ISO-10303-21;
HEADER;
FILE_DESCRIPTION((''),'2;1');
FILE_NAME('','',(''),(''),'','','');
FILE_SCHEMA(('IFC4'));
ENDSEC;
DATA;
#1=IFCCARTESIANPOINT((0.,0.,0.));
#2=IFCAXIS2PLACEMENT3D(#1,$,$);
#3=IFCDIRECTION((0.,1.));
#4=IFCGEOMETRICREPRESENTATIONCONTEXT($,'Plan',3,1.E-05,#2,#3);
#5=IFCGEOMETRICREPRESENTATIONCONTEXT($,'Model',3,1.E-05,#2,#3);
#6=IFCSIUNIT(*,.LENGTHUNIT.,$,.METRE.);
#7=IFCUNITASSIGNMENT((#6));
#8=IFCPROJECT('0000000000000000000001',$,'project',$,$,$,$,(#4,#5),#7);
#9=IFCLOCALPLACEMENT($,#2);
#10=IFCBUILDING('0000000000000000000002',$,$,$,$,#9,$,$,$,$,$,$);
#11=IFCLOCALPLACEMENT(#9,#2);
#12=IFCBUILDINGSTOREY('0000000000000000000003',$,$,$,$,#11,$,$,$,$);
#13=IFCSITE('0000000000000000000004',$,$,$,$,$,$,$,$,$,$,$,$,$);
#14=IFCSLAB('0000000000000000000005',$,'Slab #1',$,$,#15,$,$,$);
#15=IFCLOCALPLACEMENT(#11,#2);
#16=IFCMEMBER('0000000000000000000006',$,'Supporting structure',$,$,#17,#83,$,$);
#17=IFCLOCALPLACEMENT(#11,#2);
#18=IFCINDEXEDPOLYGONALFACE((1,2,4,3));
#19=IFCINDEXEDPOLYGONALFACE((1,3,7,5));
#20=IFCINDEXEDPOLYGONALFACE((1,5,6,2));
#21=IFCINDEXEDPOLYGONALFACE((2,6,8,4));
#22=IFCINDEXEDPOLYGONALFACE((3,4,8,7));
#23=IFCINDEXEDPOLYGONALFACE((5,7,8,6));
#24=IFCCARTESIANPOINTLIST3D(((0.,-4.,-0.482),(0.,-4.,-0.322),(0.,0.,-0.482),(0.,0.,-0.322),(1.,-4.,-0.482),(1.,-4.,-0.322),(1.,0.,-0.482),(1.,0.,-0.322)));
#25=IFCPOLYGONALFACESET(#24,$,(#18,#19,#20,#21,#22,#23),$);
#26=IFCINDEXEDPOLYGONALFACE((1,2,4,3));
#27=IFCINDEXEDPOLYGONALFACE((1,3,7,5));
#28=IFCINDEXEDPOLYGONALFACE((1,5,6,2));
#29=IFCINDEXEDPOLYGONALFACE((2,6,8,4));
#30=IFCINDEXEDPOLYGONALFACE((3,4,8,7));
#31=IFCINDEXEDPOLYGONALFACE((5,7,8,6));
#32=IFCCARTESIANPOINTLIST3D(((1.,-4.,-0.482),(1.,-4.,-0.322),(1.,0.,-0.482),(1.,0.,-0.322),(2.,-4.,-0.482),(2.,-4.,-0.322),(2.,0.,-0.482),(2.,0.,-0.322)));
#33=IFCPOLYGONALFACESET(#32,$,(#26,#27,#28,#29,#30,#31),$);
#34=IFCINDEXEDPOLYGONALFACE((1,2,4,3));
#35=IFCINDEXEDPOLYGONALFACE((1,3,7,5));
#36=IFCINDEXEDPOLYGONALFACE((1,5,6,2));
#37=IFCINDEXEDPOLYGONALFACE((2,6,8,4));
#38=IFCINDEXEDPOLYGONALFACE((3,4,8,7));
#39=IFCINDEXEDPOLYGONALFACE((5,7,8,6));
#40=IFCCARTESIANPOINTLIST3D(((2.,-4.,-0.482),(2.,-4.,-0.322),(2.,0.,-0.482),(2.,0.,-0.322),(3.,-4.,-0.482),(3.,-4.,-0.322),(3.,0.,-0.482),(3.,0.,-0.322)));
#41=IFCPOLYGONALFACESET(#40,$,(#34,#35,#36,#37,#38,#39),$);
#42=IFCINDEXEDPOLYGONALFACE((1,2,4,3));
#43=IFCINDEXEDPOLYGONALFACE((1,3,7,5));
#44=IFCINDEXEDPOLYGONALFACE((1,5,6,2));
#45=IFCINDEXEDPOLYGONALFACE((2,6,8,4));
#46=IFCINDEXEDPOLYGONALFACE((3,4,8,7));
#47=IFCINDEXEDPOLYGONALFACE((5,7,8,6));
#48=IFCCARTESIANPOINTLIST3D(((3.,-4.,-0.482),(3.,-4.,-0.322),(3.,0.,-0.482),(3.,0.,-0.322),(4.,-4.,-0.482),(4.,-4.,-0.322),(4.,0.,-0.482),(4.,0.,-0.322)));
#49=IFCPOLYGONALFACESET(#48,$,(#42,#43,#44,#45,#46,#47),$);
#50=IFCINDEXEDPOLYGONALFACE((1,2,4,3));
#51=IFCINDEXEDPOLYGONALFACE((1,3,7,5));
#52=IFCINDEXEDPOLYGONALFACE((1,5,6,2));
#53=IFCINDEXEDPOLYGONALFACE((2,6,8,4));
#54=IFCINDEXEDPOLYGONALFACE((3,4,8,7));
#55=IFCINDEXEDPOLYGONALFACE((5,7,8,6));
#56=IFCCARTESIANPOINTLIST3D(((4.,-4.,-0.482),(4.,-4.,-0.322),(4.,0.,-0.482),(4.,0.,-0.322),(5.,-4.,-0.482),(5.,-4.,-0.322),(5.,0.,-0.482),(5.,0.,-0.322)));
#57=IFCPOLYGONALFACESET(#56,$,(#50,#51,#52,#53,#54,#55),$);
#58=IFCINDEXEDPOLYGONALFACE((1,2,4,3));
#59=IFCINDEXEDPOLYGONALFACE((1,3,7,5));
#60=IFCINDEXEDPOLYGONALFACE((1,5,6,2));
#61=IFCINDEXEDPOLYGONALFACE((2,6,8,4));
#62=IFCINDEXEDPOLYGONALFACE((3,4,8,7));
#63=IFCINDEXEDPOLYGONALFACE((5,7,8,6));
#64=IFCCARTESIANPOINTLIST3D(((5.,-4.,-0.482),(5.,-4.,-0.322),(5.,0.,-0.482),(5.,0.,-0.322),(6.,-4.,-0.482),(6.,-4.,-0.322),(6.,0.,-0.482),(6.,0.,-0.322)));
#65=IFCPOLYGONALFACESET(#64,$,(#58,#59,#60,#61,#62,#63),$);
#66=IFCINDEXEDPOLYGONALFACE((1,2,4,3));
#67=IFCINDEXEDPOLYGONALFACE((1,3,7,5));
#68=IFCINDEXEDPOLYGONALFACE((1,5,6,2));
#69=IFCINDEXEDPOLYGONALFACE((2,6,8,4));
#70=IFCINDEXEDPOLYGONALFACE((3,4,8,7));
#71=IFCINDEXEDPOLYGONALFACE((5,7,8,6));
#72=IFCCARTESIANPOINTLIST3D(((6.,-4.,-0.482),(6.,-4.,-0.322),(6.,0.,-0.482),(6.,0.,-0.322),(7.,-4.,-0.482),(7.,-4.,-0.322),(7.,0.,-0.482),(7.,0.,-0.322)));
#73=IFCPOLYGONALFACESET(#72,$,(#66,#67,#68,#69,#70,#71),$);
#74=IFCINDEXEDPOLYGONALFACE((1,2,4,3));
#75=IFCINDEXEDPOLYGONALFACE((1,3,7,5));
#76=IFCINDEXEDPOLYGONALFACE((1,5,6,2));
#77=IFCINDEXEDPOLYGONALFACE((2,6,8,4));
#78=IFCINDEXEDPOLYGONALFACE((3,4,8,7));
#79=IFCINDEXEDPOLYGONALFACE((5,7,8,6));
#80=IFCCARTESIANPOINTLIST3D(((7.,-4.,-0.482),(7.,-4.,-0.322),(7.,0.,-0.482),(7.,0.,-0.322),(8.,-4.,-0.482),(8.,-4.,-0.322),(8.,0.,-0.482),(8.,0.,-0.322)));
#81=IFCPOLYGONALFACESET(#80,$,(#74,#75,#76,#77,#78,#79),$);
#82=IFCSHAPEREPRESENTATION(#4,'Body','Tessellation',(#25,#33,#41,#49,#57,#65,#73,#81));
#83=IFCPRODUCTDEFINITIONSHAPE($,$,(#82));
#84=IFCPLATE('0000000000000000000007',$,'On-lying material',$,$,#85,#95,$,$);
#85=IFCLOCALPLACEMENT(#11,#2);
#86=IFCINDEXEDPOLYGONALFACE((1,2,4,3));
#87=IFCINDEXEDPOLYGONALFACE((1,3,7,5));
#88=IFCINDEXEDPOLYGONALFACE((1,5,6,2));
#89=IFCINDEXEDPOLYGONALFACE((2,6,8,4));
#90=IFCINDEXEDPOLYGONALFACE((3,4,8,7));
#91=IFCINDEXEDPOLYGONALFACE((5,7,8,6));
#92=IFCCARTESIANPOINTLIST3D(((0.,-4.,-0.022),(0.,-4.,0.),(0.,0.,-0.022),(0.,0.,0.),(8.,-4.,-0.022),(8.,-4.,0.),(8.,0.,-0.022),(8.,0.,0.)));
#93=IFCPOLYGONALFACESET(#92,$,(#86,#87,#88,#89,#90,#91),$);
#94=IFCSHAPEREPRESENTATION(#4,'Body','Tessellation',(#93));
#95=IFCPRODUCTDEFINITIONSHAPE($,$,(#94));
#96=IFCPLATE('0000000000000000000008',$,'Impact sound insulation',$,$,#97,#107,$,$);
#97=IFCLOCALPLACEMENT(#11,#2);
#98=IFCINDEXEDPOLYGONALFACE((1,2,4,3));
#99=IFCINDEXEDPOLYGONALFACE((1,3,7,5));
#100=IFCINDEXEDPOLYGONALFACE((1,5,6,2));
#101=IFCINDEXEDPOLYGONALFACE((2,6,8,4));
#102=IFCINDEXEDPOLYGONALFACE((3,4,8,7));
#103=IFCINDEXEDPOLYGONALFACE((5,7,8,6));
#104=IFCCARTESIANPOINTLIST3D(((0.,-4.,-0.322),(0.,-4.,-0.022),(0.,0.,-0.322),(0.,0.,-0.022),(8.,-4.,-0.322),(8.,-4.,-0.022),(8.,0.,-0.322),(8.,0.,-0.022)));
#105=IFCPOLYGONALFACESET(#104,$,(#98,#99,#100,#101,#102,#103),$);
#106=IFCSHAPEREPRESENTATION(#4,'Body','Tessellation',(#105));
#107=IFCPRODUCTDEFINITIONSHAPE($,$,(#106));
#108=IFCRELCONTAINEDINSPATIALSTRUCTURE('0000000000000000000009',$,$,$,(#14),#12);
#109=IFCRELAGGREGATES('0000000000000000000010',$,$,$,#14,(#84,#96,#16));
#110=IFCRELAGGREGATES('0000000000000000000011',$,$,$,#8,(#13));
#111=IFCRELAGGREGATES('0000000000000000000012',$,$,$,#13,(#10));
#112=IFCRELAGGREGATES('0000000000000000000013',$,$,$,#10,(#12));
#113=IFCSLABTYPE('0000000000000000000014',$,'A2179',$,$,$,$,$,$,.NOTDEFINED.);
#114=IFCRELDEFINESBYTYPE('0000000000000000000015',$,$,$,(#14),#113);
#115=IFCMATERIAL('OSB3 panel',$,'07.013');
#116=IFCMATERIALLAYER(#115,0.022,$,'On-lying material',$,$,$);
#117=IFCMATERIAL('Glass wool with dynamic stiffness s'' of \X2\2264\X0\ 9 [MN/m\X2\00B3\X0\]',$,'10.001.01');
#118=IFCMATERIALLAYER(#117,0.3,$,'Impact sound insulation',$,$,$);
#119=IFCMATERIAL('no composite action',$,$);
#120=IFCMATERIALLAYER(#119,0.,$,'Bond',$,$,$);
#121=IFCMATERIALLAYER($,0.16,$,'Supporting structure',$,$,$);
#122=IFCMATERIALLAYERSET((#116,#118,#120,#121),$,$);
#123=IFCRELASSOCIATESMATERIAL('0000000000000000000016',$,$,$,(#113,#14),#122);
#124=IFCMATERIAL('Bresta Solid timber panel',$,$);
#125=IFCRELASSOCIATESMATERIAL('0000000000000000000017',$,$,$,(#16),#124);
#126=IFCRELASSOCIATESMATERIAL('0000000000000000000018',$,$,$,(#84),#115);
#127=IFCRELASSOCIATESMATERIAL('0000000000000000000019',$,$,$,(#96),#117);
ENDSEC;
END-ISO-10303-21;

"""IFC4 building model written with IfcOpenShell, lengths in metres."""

from ifc_helpers import new_model, si_unit, direction, frame, frame_2d, origin, origin_with_axes, place, context, project, spatial, rectangle, extrude, material, layer, layer_set, type_object, element, aggregate, save


model = new_model("IFC4")

# Units and contexts
plan_context = context("Plan", 3, precision=1e-05, world=origin(), true_north=direction((0.0, 1.0)))
model_context = context("Model", 3, precision=1e-05, world=origin(), true_north=direction((0.0, 1.0)))
ifc_project = project(units=[si_unit("LENGTHUNIT", "METRE")], contexts=[plan_context, model_context])

# Site, building, storey
site = spatial("IfcSite", under=ifc_project)
building_placement = place(None, origin())
building = spatial("IfcBuilding", under=site, at=building_placement)
storey_placement = place(building_placement, origin())
storey = spatial("IfcBuildingStorey", under=building, at=storey_placement)

# Slab, member, plates
ifc_material_1 = material(Name="OSB3 panel", Category="07.013")
ifc_layer_1 = layer(ifc_material_1, 0.022, Name="On-lying material")
ifc_material_2 = material(Name="Glass wool with dynamic stiffness s' of ≤ 9 [MN/m³]", Category="10.001.01")
ifc_layer_2 = layer(ifc_material_2, 0.3, Name="Impact sound insulation")
ifc_material_3 = material(Name="no composite action")
ifc_layer_3 = layer(ifc_material_3, 0.0, Name="Bond")
ifc_layer_4 = layer(None, 0.16, Name="Supporting structure")
ifc_layer_set = layer_set([ifc_layer_1, ifc_layer_2, ifc_layer_3, ifc_layer_4])
slab_type = type_object("IfcSlabType", Name="A2179", PredefinedType="NOTDEFINED", material=ifc_layer_set)
slab_placement = place(None, frame((0.0, 0.0, 0.0), z_axis=(0.0, 0.0, -1.0), x_axis=(1.0, 0.0, 0.0)))
slab = element("IfcSlab", 1, at=slab_placement, inside=storey, type_object=slab_type, material=ifc_layer_set, Name="Slab #1")
ifc_material_4 = material(Name="Bresta Solid timber panel")
member_placement = place(slab_placement, origin())
member = element("IfcMember", 2, at=member_placement, material=ifc_material_4, Name="Supporting structure", context=plan_context, shape_type="SweptSolid", body=[
    extrude(rectangle(XDim=1.0, YDim=0.16, at=frame_2d((0.5, 0.08), x_axis=(1.0, 0.0))), frame((0.0, 4.0, 0.322), z_axis=(0.0, -1.0, 0.0), x_axis=(1.0, 0.0, 0.0)), (0.0, 0.0, 1.0), 4.0),
    extrude(rectangle(XDim=1.0, YDim=0.16, at=frame_2d((0.5, 0.08), x_axis=(1.0, 0.0))), frame((1.0, 4.0, 0.322), z_axis=(0.0, -1.0, 0.0), x_axis=(1.0, 0.0, 0.0)), (0.0, 0.0, 1.0), 4.0),
    extrude(rectangle(XDim=1.0, YDim=0.16, at=frame_2d((0.5, 0.08), x_axis=(1.0, 0.0))), frame((2.0, 4.0, 0.322), z_axis=(0.0, -1.0, 0.0), x_axis=(1.0, 0.0, 0.0)), (0.0, 0.0, 1.0), 4.0),
    extrude(rectangle(XDim=1.0, YDim=0.16, at=frame_2d((0.5, 0.08), x_axis=(1.0, 0.0))), frame((3.0, 4.0, 0.322), z_axis=(0.0, -1.0, 0.0), x_axis=(1.0, 0.0, 0.0)), (0.0, 0.0, 1.0), 4.0),
    extrude(rectangle(XDim=1.0, YDim=0.16, at=frame_2d((0.5, 0.08), x_axis=(1.0, 0.0))), frame((4.0, 4.0, 0.322), z_axis=(0.0, -1.0, 0.0), x_axis=(1.0, 0.0, 0.0)), (0.0, 0.0, 1.0), 4.0),
    extrude(rectangle(XDim=1.0, YDim=0.16, at=frame_2d((0.5, 0.08), x_axis=(1.0, 0.0))), frame((5.0, 4.0, 0.322), z_axis=(0.0, -1.0, 0.0), x_axis=(1.0, 0.0, 0.0)), (0.0, 0.0, 1.0), 4.0),
    extrude(rectangle(XDim=1.0, YDim=0.16, at=frame_2d((0.5, 0.08), x_axis=(1.0, 0.0))), frame((6.0, 4.0, 0.322), z_axis=(0.0, -1.0, 0.0), x_axis=(1.0, 0.0, 0.0)), (0.0, 0.0, 1.0), 4.0),
    extrude(rectangle(XDim=1.0, YDim=0.16, at=frame_2d((0.5, 0.08), x_axis=(1.0, 0.0))), frame((7.0, 4.0, 0.322), z_axis=(0.0, -1.0, 0.0), x_axis=(1.0, 0.0, 0.0)), (0.0, 0.0, 1.0), 4.0),
])
plate_1_placement = place(slab_placement, origin())
plate_1 = element("IfcPlate", 3, at=plate_1_placement, material=ifc_material_1, Name="On-lying material", context=plan_context, shape_type="SweptSolid", body=[
    extrude(rectangle(XDim=8.0, YDim=4.0, at=frame_2d((4.0, 2.0), x_axis=(1.0, 0.0))), origin_with_axes(), (0.0, 0.0, 1.0), 0.022),
])
plate_2_placement = place(slab_placement, origin())
plate_2 = element("IfcPlate", 4, at=plate_2_placement, material=ifc_material_2, Name="Impact sound insulation", context=plan_context, shape_type="SweptSolid", body=[
    extrude(rectangle(XDim=8.0, YDim=4.0, at=frame_2d((4.0, 2.0), x_axis=(1.0, 0.0))), frame((0.0, 0.0, 0.022), z_axis=(0.0, 0.0, 1.0), x_axis=(1.0, 0.0, 0.0)), (0.0, 0.0, 1.0), 0.3),
])
aggregate(slab, [plate_1, plate_2, member])

save(model, "model.ifc")
